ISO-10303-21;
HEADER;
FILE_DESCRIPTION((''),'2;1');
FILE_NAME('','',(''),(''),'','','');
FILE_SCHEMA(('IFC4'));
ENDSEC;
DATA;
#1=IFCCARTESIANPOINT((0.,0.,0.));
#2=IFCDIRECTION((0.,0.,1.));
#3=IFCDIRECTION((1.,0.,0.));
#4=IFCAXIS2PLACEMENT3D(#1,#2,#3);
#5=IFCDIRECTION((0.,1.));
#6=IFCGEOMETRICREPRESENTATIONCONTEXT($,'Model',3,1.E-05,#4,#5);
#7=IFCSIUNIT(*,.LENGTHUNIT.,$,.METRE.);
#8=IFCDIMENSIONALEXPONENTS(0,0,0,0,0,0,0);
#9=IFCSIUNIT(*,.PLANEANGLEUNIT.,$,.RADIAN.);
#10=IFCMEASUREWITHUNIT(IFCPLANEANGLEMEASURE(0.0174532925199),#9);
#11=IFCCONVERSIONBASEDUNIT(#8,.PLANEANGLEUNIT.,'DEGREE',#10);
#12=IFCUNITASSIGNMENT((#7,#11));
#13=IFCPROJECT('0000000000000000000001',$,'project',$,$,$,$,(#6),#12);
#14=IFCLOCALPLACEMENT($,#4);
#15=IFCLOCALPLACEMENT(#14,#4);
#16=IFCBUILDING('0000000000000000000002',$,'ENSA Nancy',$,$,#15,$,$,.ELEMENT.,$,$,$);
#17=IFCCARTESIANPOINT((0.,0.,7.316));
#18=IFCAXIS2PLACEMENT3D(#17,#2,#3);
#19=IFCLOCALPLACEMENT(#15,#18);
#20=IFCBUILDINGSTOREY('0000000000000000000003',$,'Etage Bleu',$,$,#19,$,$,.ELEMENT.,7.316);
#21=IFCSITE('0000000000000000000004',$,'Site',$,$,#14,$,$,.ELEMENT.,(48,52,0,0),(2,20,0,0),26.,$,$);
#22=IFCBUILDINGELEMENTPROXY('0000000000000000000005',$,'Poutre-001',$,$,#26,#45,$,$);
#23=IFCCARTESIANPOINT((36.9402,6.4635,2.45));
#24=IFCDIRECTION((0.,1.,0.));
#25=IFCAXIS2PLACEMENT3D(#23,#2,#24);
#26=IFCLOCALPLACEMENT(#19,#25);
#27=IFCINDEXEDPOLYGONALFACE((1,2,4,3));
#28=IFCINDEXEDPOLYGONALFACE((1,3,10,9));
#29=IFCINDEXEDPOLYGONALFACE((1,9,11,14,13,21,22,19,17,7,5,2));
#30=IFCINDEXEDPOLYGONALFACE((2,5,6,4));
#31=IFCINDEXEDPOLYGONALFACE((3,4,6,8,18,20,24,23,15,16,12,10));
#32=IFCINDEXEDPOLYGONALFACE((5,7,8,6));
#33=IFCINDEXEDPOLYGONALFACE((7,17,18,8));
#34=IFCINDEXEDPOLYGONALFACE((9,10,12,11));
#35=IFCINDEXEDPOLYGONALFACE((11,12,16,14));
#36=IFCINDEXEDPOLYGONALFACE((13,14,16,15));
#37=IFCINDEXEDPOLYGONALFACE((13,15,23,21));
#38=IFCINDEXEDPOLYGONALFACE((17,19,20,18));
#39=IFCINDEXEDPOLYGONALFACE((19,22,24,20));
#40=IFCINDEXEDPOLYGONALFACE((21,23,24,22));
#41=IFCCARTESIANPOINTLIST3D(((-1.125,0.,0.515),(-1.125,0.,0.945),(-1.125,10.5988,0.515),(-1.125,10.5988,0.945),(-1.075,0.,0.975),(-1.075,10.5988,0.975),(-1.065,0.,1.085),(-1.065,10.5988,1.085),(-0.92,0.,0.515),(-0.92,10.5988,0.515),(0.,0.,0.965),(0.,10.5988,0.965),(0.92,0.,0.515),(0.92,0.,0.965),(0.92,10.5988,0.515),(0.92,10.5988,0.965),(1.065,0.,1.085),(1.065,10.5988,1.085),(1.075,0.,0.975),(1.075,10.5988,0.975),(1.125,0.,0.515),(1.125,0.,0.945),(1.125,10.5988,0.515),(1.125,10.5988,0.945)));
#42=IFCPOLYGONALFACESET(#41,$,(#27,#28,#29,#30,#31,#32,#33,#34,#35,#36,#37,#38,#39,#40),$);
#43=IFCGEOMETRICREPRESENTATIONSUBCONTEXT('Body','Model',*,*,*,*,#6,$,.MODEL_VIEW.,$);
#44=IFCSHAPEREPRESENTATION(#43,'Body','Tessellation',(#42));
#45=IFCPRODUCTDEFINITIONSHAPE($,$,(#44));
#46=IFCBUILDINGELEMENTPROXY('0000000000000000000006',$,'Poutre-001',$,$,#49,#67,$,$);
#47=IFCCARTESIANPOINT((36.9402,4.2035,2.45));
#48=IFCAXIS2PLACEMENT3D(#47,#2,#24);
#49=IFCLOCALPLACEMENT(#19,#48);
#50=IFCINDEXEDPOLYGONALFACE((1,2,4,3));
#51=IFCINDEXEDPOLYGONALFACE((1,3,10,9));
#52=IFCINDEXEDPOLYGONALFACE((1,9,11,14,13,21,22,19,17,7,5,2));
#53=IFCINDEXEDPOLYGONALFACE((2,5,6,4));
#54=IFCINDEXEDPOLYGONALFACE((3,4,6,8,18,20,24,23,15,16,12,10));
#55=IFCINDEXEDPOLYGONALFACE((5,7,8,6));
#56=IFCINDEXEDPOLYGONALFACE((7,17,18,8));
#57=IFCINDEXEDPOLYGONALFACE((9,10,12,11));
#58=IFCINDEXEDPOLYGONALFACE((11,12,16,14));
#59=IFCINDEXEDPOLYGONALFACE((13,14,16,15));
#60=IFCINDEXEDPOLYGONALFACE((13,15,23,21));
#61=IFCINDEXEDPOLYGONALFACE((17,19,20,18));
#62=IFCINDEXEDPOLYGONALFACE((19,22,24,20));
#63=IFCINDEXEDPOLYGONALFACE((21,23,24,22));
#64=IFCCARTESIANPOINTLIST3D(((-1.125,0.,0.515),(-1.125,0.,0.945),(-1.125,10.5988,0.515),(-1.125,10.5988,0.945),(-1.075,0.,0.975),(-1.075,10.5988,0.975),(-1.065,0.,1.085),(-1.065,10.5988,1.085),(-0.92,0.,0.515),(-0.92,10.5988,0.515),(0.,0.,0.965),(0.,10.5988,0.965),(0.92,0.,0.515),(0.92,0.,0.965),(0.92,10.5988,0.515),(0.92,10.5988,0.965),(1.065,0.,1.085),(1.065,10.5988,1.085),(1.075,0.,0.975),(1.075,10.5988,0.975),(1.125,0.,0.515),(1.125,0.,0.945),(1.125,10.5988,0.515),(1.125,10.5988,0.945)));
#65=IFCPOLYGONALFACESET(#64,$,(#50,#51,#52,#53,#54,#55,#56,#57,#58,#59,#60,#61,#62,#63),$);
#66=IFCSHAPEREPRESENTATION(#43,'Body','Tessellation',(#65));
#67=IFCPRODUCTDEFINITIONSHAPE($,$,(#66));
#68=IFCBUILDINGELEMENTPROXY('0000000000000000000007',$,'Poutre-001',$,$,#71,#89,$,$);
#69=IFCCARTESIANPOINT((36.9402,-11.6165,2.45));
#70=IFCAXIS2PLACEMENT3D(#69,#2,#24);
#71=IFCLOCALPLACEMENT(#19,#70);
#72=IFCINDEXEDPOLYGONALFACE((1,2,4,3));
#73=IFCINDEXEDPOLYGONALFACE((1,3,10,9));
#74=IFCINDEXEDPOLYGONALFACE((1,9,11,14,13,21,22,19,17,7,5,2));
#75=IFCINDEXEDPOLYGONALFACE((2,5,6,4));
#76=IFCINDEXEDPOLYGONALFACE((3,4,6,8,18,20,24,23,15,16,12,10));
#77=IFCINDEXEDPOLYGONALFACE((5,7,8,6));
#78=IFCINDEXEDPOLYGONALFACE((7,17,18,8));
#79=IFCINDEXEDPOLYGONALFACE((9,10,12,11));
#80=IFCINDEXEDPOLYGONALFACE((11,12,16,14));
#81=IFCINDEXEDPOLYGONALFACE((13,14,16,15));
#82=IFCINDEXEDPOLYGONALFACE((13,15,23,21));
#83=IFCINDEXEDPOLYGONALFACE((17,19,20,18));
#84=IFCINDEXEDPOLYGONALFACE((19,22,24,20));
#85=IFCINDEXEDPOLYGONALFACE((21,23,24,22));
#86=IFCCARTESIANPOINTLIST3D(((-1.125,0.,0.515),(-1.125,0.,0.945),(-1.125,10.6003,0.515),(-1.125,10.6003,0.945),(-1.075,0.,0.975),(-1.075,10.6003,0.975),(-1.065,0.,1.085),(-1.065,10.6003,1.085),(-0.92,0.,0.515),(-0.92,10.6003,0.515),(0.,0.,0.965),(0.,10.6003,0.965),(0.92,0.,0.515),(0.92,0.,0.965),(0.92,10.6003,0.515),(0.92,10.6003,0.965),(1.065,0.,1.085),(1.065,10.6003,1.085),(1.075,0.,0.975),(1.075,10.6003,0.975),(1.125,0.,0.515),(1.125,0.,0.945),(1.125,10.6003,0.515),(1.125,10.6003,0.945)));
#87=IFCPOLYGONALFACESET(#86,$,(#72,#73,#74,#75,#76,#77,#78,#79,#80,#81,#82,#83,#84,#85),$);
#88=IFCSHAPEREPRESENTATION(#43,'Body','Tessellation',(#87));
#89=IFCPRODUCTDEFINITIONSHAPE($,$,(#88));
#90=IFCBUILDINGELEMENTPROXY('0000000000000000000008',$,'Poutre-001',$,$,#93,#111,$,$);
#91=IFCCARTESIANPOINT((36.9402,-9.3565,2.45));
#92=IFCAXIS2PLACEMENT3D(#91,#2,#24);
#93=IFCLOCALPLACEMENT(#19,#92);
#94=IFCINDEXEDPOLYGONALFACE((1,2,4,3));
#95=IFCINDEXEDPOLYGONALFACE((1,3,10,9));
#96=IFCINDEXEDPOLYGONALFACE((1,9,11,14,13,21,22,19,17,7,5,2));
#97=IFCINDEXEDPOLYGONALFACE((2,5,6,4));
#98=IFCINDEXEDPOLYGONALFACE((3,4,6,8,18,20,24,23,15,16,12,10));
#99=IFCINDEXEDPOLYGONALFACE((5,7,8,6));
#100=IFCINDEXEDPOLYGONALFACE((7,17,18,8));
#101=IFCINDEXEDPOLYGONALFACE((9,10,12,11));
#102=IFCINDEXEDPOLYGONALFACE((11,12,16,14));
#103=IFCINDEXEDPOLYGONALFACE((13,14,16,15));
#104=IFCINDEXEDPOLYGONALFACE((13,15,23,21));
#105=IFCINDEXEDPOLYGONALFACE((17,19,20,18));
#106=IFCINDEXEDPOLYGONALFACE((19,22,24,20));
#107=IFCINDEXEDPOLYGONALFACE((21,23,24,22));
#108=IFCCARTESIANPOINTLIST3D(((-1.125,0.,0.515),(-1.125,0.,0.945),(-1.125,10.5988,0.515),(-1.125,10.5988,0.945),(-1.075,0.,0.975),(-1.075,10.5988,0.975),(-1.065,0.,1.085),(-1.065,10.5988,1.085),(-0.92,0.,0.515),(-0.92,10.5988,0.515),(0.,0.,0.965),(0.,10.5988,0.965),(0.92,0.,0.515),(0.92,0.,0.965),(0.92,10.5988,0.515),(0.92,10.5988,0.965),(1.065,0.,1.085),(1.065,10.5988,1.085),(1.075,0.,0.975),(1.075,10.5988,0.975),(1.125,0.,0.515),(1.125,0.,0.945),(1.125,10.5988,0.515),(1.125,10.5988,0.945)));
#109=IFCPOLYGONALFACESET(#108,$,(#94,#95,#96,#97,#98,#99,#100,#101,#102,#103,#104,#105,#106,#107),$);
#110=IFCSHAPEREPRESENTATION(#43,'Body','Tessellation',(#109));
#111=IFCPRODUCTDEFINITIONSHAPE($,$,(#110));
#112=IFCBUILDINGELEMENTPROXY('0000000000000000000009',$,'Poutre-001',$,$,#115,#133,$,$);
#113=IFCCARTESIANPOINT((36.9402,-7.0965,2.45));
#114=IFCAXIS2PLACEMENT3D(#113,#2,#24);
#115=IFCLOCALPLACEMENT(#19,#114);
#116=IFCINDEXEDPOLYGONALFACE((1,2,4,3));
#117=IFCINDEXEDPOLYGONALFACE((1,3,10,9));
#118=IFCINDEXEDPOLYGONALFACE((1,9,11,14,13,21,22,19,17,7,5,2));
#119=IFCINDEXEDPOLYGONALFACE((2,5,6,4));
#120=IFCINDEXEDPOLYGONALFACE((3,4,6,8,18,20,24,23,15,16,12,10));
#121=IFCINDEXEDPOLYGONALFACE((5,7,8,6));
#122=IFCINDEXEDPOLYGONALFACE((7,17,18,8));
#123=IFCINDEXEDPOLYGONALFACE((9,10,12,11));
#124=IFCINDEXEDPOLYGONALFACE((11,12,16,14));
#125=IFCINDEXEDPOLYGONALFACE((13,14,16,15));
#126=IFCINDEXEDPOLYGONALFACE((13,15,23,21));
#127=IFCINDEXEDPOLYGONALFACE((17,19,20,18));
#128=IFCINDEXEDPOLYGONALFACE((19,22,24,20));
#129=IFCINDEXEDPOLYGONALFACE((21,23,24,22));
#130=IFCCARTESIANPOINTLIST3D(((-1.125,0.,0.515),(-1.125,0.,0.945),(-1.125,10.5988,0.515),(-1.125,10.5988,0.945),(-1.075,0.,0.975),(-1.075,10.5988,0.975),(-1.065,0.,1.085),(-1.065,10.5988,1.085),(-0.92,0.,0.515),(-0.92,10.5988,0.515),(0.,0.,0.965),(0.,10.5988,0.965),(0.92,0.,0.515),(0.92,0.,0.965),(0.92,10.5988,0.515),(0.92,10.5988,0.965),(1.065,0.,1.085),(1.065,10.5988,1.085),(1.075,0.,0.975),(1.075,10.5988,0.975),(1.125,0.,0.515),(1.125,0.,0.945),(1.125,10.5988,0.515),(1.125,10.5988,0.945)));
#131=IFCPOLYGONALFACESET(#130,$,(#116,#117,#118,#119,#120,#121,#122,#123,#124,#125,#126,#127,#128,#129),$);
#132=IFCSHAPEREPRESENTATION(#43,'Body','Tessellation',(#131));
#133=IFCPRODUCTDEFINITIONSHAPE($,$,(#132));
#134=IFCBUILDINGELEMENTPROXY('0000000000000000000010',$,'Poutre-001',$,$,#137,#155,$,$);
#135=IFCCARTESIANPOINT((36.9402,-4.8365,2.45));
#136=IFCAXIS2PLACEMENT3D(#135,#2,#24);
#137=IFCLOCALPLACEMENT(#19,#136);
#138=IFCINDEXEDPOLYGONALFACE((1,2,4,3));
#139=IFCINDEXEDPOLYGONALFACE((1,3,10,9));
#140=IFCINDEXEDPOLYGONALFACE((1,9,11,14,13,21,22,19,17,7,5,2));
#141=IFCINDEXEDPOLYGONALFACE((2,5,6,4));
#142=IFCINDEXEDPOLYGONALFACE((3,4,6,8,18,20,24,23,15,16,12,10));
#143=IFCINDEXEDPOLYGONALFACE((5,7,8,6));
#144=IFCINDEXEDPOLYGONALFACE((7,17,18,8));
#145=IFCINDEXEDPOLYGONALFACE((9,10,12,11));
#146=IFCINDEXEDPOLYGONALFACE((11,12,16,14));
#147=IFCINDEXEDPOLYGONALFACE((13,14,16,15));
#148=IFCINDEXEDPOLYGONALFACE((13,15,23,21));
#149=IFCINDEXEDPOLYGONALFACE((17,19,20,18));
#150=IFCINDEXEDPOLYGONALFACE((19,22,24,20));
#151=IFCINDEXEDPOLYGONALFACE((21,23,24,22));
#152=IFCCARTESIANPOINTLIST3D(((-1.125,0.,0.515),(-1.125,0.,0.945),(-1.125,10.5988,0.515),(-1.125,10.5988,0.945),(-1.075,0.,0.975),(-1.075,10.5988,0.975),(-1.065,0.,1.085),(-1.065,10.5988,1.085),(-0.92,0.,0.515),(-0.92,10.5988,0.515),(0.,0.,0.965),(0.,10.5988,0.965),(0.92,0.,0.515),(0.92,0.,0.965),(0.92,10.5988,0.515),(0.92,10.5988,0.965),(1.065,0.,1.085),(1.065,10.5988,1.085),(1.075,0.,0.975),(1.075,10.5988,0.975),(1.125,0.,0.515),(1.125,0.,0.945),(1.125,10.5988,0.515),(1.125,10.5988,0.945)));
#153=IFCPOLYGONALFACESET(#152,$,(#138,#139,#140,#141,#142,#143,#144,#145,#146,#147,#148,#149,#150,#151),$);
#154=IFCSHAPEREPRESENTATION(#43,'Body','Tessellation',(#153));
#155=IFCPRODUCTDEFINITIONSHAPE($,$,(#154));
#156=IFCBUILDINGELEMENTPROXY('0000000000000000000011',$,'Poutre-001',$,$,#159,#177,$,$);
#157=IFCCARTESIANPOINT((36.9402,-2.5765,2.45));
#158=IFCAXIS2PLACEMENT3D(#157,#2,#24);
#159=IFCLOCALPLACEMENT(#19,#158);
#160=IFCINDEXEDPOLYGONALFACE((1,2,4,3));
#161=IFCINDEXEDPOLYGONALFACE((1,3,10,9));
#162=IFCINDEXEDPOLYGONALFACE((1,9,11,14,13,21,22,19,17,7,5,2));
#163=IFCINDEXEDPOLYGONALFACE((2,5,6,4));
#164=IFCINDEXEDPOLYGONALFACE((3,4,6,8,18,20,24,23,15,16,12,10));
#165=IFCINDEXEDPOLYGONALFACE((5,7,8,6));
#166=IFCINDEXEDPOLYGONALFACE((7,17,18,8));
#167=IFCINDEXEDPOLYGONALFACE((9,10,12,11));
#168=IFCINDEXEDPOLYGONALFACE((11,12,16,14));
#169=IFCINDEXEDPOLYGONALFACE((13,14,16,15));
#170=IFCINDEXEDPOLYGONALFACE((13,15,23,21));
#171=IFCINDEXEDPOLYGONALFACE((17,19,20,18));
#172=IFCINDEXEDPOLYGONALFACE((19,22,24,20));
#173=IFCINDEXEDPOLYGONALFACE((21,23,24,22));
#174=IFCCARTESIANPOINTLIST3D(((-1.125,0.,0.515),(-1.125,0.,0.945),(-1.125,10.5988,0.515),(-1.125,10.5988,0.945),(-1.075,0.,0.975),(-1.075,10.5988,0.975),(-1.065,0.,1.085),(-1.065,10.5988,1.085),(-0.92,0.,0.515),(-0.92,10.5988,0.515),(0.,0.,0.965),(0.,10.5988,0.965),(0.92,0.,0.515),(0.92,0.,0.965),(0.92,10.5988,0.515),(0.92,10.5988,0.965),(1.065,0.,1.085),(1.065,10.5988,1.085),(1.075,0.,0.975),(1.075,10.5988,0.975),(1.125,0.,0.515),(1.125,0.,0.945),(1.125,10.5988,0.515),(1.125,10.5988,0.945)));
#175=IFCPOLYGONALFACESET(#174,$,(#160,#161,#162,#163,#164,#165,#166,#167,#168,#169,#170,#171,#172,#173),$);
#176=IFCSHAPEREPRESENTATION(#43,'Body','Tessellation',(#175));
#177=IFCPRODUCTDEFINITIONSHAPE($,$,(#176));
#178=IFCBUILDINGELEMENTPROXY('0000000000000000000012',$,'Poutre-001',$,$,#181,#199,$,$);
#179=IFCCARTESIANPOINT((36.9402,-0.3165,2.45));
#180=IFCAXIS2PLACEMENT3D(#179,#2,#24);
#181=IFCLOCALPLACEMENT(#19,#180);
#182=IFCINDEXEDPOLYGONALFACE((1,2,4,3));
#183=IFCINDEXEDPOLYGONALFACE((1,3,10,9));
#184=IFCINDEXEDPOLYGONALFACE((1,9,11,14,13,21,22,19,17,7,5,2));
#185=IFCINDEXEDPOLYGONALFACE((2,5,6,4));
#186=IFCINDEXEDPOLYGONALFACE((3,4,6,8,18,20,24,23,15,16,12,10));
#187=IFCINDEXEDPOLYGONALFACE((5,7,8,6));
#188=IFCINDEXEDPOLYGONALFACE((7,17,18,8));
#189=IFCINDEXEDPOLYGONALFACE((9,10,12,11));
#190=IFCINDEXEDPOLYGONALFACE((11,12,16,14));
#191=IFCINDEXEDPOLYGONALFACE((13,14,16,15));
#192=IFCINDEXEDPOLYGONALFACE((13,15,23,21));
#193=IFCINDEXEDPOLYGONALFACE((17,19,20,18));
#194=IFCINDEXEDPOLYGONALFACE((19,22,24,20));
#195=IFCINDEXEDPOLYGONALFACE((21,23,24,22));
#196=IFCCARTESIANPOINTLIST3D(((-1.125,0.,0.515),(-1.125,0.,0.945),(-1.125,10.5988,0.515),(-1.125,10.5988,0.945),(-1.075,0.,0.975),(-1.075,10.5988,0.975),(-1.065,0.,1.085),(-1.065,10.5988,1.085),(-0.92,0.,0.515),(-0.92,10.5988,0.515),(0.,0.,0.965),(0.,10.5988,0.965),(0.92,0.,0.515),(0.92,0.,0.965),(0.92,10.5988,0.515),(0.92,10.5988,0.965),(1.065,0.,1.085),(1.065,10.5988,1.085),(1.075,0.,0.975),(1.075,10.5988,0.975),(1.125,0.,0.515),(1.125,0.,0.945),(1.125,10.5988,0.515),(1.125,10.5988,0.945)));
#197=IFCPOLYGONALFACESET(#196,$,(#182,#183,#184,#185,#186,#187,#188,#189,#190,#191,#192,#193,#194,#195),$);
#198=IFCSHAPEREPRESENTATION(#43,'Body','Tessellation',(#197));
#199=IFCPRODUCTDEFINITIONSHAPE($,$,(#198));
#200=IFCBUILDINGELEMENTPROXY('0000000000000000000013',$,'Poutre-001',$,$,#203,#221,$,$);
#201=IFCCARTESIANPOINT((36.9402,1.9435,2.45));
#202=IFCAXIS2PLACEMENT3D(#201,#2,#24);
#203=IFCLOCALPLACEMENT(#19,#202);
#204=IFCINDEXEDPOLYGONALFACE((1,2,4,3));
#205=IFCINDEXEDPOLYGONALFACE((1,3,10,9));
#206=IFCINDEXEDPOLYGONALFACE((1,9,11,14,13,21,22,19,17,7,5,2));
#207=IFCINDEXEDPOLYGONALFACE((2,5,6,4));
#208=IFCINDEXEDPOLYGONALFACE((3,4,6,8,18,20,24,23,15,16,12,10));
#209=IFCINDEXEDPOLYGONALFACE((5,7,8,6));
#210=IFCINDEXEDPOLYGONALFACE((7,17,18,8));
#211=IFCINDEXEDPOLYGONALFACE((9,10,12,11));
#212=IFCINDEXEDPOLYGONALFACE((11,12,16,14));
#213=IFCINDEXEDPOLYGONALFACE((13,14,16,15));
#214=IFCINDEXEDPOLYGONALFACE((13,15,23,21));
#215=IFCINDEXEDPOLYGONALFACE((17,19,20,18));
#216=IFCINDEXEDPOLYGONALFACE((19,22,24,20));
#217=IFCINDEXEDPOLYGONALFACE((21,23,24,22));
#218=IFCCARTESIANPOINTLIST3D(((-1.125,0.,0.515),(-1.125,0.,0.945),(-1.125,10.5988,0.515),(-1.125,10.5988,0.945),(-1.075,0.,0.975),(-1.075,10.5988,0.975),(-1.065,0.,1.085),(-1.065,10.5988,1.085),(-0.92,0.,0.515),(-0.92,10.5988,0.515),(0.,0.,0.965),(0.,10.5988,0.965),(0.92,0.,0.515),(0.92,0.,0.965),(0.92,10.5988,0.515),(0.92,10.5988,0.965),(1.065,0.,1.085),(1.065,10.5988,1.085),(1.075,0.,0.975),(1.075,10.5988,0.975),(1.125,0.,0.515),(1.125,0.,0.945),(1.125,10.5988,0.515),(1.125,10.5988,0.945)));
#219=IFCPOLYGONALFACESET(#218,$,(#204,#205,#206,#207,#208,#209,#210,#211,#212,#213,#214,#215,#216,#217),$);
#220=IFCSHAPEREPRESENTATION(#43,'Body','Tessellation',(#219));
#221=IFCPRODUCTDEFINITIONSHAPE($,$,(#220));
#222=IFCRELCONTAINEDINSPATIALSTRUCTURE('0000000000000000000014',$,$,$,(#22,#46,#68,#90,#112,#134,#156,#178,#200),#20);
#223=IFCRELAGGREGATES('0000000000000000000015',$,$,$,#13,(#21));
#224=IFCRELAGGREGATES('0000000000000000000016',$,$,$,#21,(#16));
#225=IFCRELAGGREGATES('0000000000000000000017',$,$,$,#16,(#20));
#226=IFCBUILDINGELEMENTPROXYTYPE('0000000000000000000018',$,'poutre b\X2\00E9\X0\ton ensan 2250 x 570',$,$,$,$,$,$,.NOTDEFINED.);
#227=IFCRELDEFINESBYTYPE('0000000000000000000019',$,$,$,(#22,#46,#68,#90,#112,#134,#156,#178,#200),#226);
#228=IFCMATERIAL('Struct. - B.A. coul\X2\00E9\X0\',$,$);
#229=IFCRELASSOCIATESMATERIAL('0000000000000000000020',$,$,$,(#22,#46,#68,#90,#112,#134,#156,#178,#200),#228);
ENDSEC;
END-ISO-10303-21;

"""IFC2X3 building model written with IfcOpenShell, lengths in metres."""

from ifc_helpers import new_model, entity, si_unit, converted_unit, direction, frame, origin_with_axes, place, context, subcontext, project, spatial, polyline, outline, extrude, material, type_object, element, save


model = new_model("IFC2X3")

# Units and contexts
model_context = context("Model", 3, precision=1e-05, world=origin_with_axes(), true_north=direction((0.0, 1.0)))
body_context = subcontext(model_context, "Body", "Model", "MODEL_VIEW")
ifc_project = project(units=[si_unit("LENGTHUNIT", "METRE"), converted_unit("PLANEANGLEUNIT", "DEGREE", entity("IfcPlaneAngleMeasure", 0.0174532925199), si_unit("PLANEANGLEUNIT", "RADIAN"), dimensions=[0, 0, 0, 0, 0, 0, 0])], contexts=[model_context])

# Site, building, storey
site_placement = place(None, origin_with_axes())
site = spatial("IfcSite", under=ifc_project, at=site_placement, Name="Site", CompositionType="ELEMENT", RefLatitude=(48, 52, 0, 0), RefLongitude=(2, 20, 0, 0), RefElevation=26.0)
building_placement = place(site_placement, origin_with_axes())
building = spatial("IfcBuilding", under=site, at=building_placement, Name="ENSA Nancy", CompositionType="ELEMENT")
storey_placement = place(building_placement, frame((0.0, 0.0, 7.316), z_axis=(0.0, 0.0, 1.0), x_axis=(1.0, 0.0, 0.0)))
storey = spatial("IfcBuildingStorey", under=building, at=storey_placement, Name="Etage Bleu", CompositionType="ELEMENT", Elevation=7.316)

# Building element proxies
ifc_material_1 = material(Name="Struct. - B.A. coulé")
building_element_proxy_type_1 = type_object("IfcBuildingElementProxyType", Name="poutre béton ensan 2250 x 570", PredefinedType="NOTDEFINED")
proxy_1_placement = place(storey_placement, frame((36.9402, 6.4635, 2.45), z_axis=(0.0, 0.0, 1.0), x_axis=(0.0, 1.0, 0.0)))
element("IfcBuildingElementProxy", 1, at=proxy_1_placement, inside=storey, type_object=building_element_proxy_type_1, material=ifc_material_1, Name="Poutre-001", context=body_context, shape_type="SweptSolid", body=[
    extrude(outline(polyline([(-1.065, 1.085), (-1.075, 0.975), (-1.125, 0.945), (-1.125, 0.515), (-0.92, 0.515), (0.0, 0.965), (0.92, 0.965), (0.92, 0.515), (1.125, 0.515), (1.125, 0.945), (1.075, 0.975), (1.065, 1.085), (-1.065, 1.085)])), frame((0.0, 10.5988, 0.0), z_axis=(0.0, -1.0, 0.0), x_axis=(1.0, 0.0, 0.0)), (0.0, 0.0, 1.0), 10.5988),
])
proxy_2_placement = place(storey_placement, frame((36.9402, 4.2035, 2.45), z_axis=(0.0, 0.0, 1.0), x_axis=(0.0, 1.0, 0.0)))
element("IfcBuildingElementProxy", 2, at=proxy_2_placement, inside=storey, type_object=building_element_proxy_type_1, material=ifc_material_1, Name="Poutre-001", context=body_context, shape_type="SweptSolid", body=[
    extrude(outline(polyline([(-1.065, 1.085), (-1.075, 0.975), (-1.125, 0.945), (-1.125, 0.515), (-0.92, 0.515), (0.0, 0.965), (0.92, 0.965), (0.92, 0.515), (1.125, 0.515), (1.125, 0.945), (1.075, 0.975), (1.065, 1.085), (-1.065, 1.085)])), frame((0.0, 10.5988, 0.0), z_axis=(0.0, -1.0, 0.0), x_axis=(1.0, 0.0, 0.0)), (0.0, 0.0, 1.0), 10.5988),
])
proxy_3_placement = place(storey_placement, frame((36.9402, -11.6165, 2.45), z_axis=(0.0, 0.0, 1.0), x_axis=(0.0, 1.0, 0.0)))
element("IfcBuildingElementProxy", 3, at=proxy_3_placement, inside=storey, type_object=building_element_proxy_type_1, material=ifc_material_1, Name="Poutre-001", context=body_context, shape_type="SweptSolid", body=[
    extrude(outline(polyline([(-1.065, 1.085), (-1.075, 0.975), (-1.125, 0.945), (-1.125, 0.515), (-0.92, 0.515), (0.0, 0.965), (0.92, 0.965), (0.92, 0.515), (1.125, 0.515), (1.125, 0.945), (1.075, 0.975), (1.065, 1.085), (-1.065, 1.085)])), frame((0.0, 10.6003, 0.0), z_axis=(0.0, -1.0, 0.0), x_axis=(1.0, 0.0, 0.0)), (0.0, 0.0, 1.0), 10.6003),
])
for number, where, z_axis, x_axis, name in (
    (4, (36.9402, -9.3565, 2.45), (0.0, 0.0, 1.0), (0.0, 1.0, 0.0), "Poutre-001"),
    (5, (36.9402, -7.0965, 2.45), (0.0, 0.0, 1.0), (0.0, 1.0, 0.0), "Poutre-001"),
    (6, (36.9402, -4.8365, 2.45), (0.0, 0.0, 1.0), (0.0, 1.0, 0.0), "Poutre-001"),
    (7, (36.9402, -2.5765, 2.45), (0.0, 0.0, 1.0), (0.0, 1.0, 0.0), "Poutre-001"),
    (8, (36.9402, -0.3165, 2.45), (0.0, 0.0, 1.0), (0.0, 1.0, 0.0), "Poutre-001"),
    (9, (36.9402, 1.9435, 2.45), (0.0, 0.0, 1.0), (0.0, 1.0, 0.0), "Poutre-001"),
):
    element("IfcBuildingElementProxy", number, at=place(storey_placement, frame(where, z_axis=z_axis, x_axis=x_axis)), inside=storey, type_object=building_element_proxy_type_1, material=ifc_material_1, Name=name, context=body_context, shape_type="SweptSolid", body=[
        extrude(outline(polyline([(-1.065, 1.085), (-1.075, 0.975), (-1.125, 0.945), (-1.125, 0.515), (-0.92, 0.515), (0.0, 0.965), (0.92, 0.965), (0.92, 0.515), (1.125, 0.515), (1.125, 0.945), (1.075, 0.975), (1.065, 1.085), (-1.065, 1.085)])), frame((0.0, 10.5988, 0.0), z_axis=(0.0, -1.0, 0.0), x_axis=(1.0, 0.0, 0.0)), (0.0, 0.0, 1.0), 10.5988),
    ])

save(model, "model.ifc")
